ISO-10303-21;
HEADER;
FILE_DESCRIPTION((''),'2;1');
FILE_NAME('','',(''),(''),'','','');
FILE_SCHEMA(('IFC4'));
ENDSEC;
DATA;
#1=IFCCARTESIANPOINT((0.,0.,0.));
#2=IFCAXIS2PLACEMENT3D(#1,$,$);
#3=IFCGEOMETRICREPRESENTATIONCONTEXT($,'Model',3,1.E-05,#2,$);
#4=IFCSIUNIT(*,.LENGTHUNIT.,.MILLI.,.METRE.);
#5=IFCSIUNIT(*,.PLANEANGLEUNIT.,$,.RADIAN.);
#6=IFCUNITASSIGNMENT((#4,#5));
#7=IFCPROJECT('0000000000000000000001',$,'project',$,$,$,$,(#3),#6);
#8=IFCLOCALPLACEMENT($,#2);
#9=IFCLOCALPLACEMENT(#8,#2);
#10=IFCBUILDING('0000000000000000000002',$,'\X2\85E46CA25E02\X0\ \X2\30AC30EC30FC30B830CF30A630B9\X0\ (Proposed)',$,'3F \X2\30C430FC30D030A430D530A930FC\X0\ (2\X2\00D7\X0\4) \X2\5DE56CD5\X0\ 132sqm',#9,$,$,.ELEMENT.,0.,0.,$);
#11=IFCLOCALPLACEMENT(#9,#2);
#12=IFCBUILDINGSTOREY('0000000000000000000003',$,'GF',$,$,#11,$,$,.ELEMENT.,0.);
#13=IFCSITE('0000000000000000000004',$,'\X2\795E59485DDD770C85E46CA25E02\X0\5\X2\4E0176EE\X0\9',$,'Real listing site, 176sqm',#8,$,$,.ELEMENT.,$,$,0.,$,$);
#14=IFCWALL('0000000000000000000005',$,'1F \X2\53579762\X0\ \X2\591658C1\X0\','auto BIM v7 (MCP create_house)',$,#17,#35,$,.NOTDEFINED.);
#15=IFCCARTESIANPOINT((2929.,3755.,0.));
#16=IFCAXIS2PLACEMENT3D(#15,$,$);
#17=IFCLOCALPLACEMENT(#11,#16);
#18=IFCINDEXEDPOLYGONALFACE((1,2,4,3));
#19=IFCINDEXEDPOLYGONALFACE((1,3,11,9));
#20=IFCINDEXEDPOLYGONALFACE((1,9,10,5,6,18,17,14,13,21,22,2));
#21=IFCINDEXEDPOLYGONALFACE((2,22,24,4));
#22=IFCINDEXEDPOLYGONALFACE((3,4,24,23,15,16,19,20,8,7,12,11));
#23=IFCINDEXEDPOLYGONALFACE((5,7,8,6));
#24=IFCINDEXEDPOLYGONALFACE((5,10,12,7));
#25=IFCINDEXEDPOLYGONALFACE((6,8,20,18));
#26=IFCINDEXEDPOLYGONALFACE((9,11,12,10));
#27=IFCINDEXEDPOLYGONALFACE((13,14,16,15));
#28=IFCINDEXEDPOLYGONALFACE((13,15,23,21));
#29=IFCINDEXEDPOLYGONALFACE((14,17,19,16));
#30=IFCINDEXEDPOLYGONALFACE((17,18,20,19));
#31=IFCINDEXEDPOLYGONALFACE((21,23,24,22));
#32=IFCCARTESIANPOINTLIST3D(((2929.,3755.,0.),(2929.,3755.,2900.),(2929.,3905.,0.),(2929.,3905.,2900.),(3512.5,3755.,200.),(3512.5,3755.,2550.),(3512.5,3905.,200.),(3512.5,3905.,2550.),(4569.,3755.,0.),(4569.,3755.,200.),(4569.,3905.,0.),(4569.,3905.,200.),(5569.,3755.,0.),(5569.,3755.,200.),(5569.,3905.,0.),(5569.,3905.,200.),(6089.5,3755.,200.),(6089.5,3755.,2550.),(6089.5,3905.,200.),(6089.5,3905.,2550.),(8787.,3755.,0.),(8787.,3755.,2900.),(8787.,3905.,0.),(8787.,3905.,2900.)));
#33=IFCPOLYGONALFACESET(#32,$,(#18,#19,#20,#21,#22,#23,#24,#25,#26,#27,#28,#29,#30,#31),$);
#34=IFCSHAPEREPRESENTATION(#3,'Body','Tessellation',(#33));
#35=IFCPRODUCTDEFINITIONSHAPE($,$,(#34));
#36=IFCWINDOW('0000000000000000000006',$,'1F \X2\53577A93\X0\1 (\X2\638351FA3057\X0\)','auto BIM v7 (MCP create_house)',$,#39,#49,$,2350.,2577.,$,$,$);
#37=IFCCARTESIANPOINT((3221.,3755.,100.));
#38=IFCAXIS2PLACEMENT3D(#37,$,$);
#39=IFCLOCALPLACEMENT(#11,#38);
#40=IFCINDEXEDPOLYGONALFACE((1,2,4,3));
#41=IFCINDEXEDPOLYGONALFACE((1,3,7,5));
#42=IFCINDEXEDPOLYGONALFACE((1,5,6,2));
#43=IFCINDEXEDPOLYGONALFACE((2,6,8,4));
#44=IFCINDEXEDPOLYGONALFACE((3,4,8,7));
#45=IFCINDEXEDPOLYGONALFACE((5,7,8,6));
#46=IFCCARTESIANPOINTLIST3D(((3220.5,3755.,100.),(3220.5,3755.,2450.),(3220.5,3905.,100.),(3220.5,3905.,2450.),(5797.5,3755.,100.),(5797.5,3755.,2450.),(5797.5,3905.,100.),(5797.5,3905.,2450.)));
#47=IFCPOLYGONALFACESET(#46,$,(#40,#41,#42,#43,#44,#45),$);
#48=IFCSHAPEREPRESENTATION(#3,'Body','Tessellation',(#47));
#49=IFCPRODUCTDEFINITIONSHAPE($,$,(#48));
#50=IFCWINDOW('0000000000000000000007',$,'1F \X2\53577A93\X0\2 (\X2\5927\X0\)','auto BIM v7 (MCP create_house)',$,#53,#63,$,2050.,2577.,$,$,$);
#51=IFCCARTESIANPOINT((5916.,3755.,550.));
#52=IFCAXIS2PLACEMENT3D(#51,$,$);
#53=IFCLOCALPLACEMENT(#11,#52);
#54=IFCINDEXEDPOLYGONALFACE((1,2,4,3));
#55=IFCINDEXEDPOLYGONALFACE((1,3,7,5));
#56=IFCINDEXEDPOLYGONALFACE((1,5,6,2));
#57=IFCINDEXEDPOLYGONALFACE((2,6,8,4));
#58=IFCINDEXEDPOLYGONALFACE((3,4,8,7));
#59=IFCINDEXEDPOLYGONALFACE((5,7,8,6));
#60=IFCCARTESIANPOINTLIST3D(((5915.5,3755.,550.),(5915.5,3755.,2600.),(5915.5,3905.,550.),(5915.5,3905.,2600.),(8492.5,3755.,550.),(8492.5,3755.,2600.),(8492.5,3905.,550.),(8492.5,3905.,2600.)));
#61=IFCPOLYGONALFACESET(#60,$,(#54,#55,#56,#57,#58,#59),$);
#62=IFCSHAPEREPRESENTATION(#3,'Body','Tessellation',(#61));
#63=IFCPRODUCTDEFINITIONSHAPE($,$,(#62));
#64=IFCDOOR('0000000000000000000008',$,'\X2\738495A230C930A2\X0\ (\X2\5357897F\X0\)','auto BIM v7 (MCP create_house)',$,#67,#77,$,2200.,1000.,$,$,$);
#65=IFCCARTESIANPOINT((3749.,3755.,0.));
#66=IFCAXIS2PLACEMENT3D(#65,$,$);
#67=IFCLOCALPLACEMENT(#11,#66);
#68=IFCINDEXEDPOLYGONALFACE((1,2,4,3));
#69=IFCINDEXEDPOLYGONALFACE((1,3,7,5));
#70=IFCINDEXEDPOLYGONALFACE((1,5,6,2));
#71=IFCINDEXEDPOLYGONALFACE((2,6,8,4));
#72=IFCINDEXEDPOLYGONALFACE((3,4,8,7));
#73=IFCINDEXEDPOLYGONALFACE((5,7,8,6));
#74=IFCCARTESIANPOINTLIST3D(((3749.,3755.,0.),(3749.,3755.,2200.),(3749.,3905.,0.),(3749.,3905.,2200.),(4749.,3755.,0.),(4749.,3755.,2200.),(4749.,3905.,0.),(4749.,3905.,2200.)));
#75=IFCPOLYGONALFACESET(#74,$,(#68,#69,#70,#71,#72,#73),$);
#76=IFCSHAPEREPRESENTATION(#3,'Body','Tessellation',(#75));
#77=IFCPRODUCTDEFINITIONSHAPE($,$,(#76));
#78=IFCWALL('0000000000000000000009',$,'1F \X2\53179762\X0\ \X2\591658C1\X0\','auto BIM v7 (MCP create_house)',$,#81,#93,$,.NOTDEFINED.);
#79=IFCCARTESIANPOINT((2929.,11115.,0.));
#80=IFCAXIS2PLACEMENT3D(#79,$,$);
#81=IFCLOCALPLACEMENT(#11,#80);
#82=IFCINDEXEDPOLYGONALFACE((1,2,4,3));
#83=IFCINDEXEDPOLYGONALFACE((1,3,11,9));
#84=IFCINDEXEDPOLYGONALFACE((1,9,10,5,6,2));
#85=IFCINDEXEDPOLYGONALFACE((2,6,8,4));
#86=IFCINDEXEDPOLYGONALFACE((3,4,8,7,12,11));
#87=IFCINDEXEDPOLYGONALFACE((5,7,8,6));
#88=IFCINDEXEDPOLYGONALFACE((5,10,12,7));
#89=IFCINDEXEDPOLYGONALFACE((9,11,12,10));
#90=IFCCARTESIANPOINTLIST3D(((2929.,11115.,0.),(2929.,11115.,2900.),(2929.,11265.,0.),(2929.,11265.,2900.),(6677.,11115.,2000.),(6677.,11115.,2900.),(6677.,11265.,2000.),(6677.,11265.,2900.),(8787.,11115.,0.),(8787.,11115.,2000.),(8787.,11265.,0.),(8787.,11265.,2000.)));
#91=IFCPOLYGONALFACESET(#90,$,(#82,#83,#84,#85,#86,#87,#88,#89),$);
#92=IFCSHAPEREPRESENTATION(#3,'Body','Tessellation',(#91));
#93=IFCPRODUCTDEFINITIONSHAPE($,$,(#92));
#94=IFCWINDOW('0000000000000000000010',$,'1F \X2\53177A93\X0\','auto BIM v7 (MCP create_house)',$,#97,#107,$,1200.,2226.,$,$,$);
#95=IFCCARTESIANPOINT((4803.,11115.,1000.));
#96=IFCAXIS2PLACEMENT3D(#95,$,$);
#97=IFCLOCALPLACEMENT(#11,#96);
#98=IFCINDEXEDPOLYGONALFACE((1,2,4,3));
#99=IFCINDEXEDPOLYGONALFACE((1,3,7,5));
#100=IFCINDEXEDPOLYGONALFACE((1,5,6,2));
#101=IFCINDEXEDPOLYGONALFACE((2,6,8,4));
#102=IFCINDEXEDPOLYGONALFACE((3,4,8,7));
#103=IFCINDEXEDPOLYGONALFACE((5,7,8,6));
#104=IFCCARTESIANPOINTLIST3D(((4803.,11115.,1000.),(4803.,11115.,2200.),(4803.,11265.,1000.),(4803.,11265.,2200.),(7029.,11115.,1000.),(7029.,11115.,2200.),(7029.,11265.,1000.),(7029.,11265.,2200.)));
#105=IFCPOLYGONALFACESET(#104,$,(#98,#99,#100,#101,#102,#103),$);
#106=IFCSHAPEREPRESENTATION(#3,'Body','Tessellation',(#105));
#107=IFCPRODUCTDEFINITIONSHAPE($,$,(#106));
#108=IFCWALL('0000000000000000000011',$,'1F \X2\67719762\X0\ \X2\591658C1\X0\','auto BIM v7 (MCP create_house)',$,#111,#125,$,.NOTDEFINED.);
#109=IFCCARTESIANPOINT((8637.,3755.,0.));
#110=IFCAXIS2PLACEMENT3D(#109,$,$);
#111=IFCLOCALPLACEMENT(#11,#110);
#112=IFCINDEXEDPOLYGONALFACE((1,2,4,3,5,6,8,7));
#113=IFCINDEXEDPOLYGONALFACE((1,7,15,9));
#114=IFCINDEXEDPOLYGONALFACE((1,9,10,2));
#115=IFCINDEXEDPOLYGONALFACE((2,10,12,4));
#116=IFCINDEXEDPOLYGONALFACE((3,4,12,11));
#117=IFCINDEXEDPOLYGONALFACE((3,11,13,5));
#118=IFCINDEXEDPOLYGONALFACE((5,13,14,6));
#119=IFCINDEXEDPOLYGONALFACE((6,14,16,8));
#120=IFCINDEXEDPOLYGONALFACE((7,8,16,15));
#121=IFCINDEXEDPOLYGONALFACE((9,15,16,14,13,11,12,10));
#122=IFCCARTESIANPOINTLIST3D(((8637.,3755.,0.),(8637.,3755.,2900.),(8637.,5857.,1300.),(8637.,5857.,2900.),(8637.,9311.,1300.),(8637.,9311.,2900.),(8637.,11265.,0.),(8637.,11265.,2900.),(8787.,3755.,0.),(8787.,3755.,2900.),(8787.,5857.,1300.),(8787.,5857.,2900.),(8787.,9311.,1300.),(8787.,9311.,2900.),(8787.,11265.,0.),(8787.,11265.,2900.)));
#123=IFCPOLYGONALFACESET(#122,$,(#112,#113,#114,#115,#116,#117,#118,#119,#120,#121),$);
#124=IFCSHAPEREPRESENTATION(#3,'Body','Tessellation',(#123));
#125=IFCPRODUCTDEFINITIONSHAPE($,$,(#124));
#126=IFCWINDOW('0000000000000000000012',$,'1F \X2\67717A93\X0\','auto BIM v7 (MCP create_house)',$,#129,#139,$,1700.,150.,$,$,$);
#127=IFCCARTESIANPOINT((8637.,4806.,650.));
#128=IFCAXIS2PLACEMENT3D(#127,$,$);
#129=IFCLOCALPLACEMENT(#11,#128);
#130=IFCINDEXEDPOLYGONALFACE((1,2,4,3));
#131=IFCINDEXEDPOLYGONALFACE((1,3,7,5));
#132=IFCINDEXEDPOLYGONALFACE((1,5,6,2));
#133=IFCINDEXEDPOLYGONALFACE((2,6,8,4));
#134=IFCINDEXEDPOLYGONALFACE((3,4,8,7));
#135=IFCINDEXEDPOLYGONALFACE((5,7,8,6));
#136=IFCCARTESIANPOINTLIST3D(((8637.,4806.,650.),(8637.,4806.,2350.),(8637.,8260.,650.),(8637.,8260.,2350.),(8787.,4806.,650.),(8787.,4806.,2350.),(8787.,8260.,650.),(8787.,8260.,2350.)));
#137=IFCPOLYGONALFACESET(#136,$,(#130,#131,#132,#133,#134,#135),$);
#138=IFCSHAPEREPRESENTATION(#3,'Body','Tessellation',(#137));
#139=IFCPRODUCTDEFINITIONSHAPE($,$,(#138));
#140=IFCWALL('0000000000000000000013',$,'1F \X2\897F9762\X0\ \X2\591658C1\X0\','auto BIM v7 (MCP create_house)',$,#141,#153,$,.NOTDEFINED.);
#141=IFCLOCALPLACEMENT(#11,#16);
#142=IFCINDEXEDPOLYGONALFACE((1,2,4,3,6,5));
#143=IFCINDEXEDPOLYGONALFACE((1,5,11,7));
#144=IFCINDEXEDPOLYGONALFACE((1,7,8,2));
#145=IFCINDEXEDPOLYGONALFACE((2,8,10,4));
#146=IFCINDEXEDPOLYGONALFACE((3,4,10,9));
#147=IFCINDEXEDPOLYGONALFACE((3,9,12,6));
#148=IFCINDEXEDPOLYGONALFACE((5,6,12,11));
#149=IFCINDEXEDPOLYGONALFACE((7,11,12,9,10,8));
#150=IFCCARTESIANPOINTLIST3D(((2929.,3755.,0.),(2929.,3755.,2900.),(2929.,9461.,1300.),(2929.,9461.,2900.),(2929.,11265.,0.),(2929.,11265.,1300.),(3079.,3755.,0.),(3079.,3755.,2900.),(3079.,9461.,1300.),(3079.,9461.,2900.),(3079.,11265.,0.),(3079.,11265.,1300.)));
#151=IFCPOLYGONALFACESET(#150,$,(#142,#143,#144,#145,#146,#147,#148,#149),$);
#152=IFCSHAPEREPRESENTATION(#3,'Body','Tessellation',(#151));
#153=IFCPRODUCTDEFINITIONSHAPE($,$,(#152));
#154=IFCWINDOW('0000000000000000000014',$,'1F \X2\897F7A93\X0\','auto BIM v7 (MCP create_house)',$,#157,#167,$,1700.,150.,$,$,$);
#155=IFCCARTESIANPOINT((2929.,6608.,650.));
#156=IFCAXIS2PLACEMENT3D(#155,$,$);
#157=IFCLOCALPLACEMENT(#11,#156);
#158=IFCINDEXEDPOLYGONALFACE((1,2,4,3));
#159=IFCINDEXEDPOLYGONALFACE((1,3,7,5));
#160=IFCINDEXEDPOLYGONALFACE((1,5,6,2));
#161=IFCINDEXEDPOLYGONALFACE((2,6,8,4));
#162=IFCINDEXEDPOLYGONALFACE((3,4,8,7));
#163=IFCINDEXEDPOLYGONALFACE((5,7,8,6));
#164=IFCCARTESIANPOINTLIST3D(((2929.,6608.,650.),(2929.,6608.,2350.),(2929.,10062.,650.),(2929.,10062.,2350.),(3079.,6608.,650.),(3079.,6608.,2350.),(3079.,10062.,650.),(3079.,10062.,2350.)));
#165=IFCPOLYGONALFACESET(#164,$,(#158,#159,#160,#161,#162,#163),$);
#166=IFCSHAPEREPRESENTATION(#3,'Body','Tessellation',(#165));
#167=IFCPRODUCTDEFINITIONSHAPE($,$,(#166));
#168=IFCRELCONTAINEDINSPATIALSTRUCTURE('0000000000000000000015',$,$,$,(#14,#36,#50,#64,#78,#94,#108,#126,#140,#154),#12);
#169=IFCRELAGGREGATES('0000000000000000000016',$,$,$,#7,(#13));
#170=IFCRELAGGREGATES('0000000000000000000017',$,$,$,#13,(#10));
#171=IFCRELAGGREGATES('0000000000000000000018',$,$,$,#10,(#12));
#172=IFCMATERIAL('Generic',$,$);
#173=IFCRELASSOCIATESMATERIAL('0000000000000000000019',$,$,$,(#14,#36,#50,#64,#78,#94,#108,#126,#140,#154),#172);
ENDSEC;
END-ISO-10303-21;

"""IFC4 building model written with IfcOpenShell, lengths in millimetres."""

from ifc_helpers import new_model, si_unit, frame, frame_2d, origin, place, context, project, spatial, rectangle, extrude, material, element, fill, save


model = new_model("IFC4")

# Units and contexts
model_context = context("Model", 3, precision=1e-05, world=origin())
ifc_project = project(units=[si_unit("LENGTHUNIT", "METRE", prefix="MILLI"), si_unit("PLANEANGLEUNIT", "RADIAN")], contexts=[model_context])

# Site, building, storey
site_placement = place(None, origin())
site = spatial("IfcSite", under=ifc_project, at=site_placement, Name="神奈川県藤沢市5丁目9", ObjectType="Real listing site, 176sqm", CompositionType="ELEMENT", RefElevation=0.0)
building_placement = place(site_placement, origin())
building = spatial("IfcBuilding", under=site, at=building_placement, Name="藤沢市 ガレージハウス (Proposed)", ObjectType="3F ツーバイフォー (2×4) 工法 132sqm", CompositionType="ELEMENT", ElevationOfRefHeight=0.0, ElevationOfTerrain=0.0)
storey_placement = place(building_placement, origin())
storey = spatial("IfcBuildingStorey", under=building, at=storey_placement, Name="GF", CompositionType="ELEMENT", Elevation=0.0)

# Shared definitions
ifc_material = material(Name="Generic")

# Wall, openings, windows, door
wall_1_placement = place(storey_placement, frame((2929.0, 3755.0, 0.0)))
wall_1 = element("IfcWall", 1, at=wall_1_placement, inside=storey, material=ifc_material, Name="1F 南面 外壁", Description="auto BIM v7 (MCP create_house)", PredefinedType="NOTDEFINED", context=model_context, shape_type="SweptSolid", body=[
    extrude(rectangle(XDim=5858.0, YDim=150.0, at=frame_2d((2929.0, 75.0))), frame((2929.0, 3755.0, 0.0)), (0.0, 0.0, 1.0), 2900.0),
])
opening_1_placement = place(storey_placement, frame((3221.0, 3755.0, 100.0)))
opening_1 = element("IfcOpeningElement", 2, at=opening_1_placement, cuts=wall_1, PredefinedType="NOTDEFINED", context=model_context, shape_type="SweptSolid", body=[
    extrude(rectangle(XDim=2577.0, YDim=150.0, at=frame_2d((1288.0, 75.0))), frame((3221.0, 3755.0, 100.0)), (0.0, 0.0, 1.0), 2350.0),
])
opening_2_placement = place(storey_placement, frame((5916.0, 3755.0, 550.0)))
opening_2 = element("IfcOpeningElement", 3, at=opening_2_placement, cuts=wall_1, PredefinedType="NOTDEFINED", context=model_context, shape_type="SweptSolid", body=[
    extrude(rectangle(XDim=2577.0, YDim=150.0, at=frame_2d((1288.0, 75.0))), frame((5916.0, 3755.0, 550.0)), (0.0, 0.0, 1.0), 2050.0),
])
opening_3_placement = place(storey_placement, frame((3749.0, 3755.0, 0.0)))
opening_3 = element("IfcOpeningElement", 4, at=opening_3_placement, cuts=wall_1, PredefinedType="NOTDEFINED", context=model_context, shape_type="SweptSolid", body=[
    extrude(rectangle(XDim=1000.0, YDim=150.0, at=frame_2d((500.0, 75.0))), frame((3749.0, 3755.0, 0.0)), (0.0, 0.0, 1.0), 2200.0),
])
window_1_placement = place(storey_placement, frame((3221.0, 3755.0, 100.0)))
window_1 = element("IfcWindow", 5, at=window_1_placement, inside=storey, material=ifc_material, Name="1F 南窓1 (掃出し)", Description="auto BIM v7 (MCP create_house)", OverallHeight=2350.0, OverallWidth=2577.0, context=model_context, shape_type="SweptSolid", body=[
    extrude(rectangle(XDim=2577.0, YDim=150.0, at=frame_2d((1288.0, 75.0))), frame((3221.0, 3755.0, 100.0)), (0.0, 0.0, 1.0), 2350.0),
])
fill(opening_1, window_1)
window_2_placement = place(storey_placement, frame((5916.0, 3755.0, 550.0)))
window_2 = element("IfcWindow", 6, at=window_2_placement, inside=storey, material=ifc_material, Name="1F 南窓2 (大)", Description="auto BIM v7 (MCP create_house)", OverallHeight=2050.0, OverallWidth=2577.0, context=model_context, shape_type="SweptSolid", body=[
    extrude(rectangle(XDim=2577.0, YDim=150.0, at=frame_2d((1288.0, 75.0))), frame((5916.0, 3755.0, 550.0)), (0.0, 0.0, 1.0), 2050.0),
])
fill(opening_2, window_2)
door_placement = place(storey_placement, frame((3749.0, 3755.0, 0.0)))
door = element("IfcDoor", 7, at=door_placement, inside=storey, material=ifc_material, Name="玄関ドア (南西)", Description="auto BIM v7 (MCP create_house)", OverallHeight=2200.0, OverallWidth=1000.0, context=model_context, shape_type="SweptSolid", body=[
    extrude(rectangle(XDim=1000.0, YDim=150.0, at=frame_2d((500.0, 75.0))), frame((3749.0, 3755.0, 0.0)), (0.0, 0.0, 1.0), 2200.0),
])
fill(opening_3, door)

# Walls, openings, windows
wall_2_placement = place(storey_placement, frame((2929.0, 11115.0, 0.0)))
wall_2 = element("IfcWall", 8, at=wall_2_placement, inside=storey, material=ifc_material, Name="1F 北面 外壁", Description="auto BIM v7 (MCP create_house)", PredefinedType="NOTDEFINED", context=model_context, shape_type="SweptSolid", body=[
    extrude(rectangle(XDim=5858.0, YDim=150.0, at=frame_2d((2929.0, 75.0))), frame((2929.0, 11115.0, 0.0)), (0.0, 0.0, 1.0), 2900.0),
])
opening_4_placement = place(storey_placement, frame((4803.0, 11115.0, 1000.0)))
opening_4 = element("IfcOpeningElement", 9, at=opening_4_placement, cuts=wall_2, PredefinedType="NOTDEFINED", context=model_context, shape_type="SweptSolid", body=[
    extrude(rectangle(XDim=2226.0, YDim=150.0, at=frame_2d((1113.0, 75.0))), frame((4803.0, 11115.0, 1000.0)), (0.0, 0.0, 1.0), 1200.0),
])
window_3_placement = place(storey_placement, frame((4803.0, 11115.0, 1000.0)))
window_3 = element("IfcWindow", 10, at=window_3_placement, inside=storey, material=ifc_material, Name="1F 北窓", Description="auto BIM v7 (MCP create_house)", OverallHeight=1200.0, OverallWidth=2226.0, context=model_context, shape_type="SweptSolid", body=[
    extrude(rectangle(XDim=2226.0, YDim=150.0, at=frame_2d((1113.0, 75.0))), frame((4803.0, 11115.0, 1000.0)), (0.0, 0.0, 1.0), 1200.0),
])
fill(opening_4, window_3)
wall_3_placement = place(storey_placement, frame((8637.0, 3755.0, 0.0)))
wall_3 = element("IfcWall", 11, at=wall_3_placement, inside=storey, material=ifc_material, Name="1F 東面 外壁", Description="auto BIM v7 (MCP create_house)", PredefinedType="NOTDEFINED", context=model_context, shape_type="SweptSolid", body=[
    extrude(rectangle(XDim=150.0, YDim=7510.0, at=frame_2d((75.0, 3755.0))), frame((8637.0, 3755.0, 0.0)), (0.0, 0.0, 1.0), 2900.0),
])
opening_5_placement = place(storey_placement, frame((8637.0, 4806.0, 650.0)))
opening_5 = element("IfcOpeningElement", 12, at=opening_5_placement, cuts=wall_3, PredefinedType="NOTDEFINED", context=model_context, shape_type="SweptSolid", body=[
    extrude(rectangle(XDim=150.0, YDim=3454.0, at=frame_2d((75.0, 1727.0))), frame((8637.0, 4806.0, 650.0)), (0.0, 0.0, 1.0), 1700.0),
])
window_4_placement = place(storey_placement, frame((8637.0, 4806.0, 650.0)))
window_4 = element("IfcWindow", 13, at=window_4_placement, inside=storey, material=ifc_material, Name="1F 東窓", Description="auto BIM v7 (MCP create_house)", OverallHeight=1700.0, OverallWidth=150.0, context=model_context, shape_type="SweptSolid", body=[
    extrude(rectangle(XDim=150.0, YDim=3454.0, at=frame_2d((75.0, 1727.0))), frame((8637.0, 4806.0, 650.0)), (0.0, 0.0, 1.0), 1700.0),
])
fill(opening_5, window_4)
wall_4_placement = place(storey_placement, frame((2929.0, 3755.0, 0.0)))
wall_4 = element("IfcWall", 14, at=wall_4_placement, inside=storey, material=ifc_material, Name="1F 西面 外壁", Description="auto BIM v7 (MCP create_house)", PredefinedType="NOTDEFINED", context=model_context, shape_type="SweptSolid", body=[
    extrude(rectangle(XDim=150.0, YDim=7510.0, at=frame_2d((75.0, 3755.0))), frame((2929.0, 3755.0, 0.0)), (0.0, 0.0, 1.0), 2900.0),
])
opening_6_placement = place(storey_placement, frame((2929.0, 6608.0, 650.0)))
opening_6 = element("IfcOpeningElement", 15, at=opening_6_placement, cuts=wall_4, PredefinedType="NOTDEFINED", context=model_context, shape_type="SweptSolid", body=[
    extrude(rectangle(XDim=150.0, YDim=3454.0, at=frame_2d((75.0, 1727.0))), frame((2929.0, 6608.0, 650.0)), (0.0, 0.0, 1.0), 1700.0),
])
window_5_placement = place(storey_placement, frame((2929.0, 6608.0, 650.0)))
window_5 = element("IfcWindow", 16, at=window_5_placement, inside=storey, material=ifc_material, Name="1F 西窓", Description="auto BIM v7 (MCP create_house)", OverallHeight=1700.0, OverallWidth=150.0, context=model_context, shape_type="SweptSolid", body=[
    extrude(rectangle(XDim=150.0, YDim=3454.0, at=frame_2d((75.0, 1727.0))), frame((2929.0, 6608.0, 650.0)), (0.0, 0.0, 1.0), 1700.0),
])
fill(opening_6, window_5)

save(model, "model.ifc")
